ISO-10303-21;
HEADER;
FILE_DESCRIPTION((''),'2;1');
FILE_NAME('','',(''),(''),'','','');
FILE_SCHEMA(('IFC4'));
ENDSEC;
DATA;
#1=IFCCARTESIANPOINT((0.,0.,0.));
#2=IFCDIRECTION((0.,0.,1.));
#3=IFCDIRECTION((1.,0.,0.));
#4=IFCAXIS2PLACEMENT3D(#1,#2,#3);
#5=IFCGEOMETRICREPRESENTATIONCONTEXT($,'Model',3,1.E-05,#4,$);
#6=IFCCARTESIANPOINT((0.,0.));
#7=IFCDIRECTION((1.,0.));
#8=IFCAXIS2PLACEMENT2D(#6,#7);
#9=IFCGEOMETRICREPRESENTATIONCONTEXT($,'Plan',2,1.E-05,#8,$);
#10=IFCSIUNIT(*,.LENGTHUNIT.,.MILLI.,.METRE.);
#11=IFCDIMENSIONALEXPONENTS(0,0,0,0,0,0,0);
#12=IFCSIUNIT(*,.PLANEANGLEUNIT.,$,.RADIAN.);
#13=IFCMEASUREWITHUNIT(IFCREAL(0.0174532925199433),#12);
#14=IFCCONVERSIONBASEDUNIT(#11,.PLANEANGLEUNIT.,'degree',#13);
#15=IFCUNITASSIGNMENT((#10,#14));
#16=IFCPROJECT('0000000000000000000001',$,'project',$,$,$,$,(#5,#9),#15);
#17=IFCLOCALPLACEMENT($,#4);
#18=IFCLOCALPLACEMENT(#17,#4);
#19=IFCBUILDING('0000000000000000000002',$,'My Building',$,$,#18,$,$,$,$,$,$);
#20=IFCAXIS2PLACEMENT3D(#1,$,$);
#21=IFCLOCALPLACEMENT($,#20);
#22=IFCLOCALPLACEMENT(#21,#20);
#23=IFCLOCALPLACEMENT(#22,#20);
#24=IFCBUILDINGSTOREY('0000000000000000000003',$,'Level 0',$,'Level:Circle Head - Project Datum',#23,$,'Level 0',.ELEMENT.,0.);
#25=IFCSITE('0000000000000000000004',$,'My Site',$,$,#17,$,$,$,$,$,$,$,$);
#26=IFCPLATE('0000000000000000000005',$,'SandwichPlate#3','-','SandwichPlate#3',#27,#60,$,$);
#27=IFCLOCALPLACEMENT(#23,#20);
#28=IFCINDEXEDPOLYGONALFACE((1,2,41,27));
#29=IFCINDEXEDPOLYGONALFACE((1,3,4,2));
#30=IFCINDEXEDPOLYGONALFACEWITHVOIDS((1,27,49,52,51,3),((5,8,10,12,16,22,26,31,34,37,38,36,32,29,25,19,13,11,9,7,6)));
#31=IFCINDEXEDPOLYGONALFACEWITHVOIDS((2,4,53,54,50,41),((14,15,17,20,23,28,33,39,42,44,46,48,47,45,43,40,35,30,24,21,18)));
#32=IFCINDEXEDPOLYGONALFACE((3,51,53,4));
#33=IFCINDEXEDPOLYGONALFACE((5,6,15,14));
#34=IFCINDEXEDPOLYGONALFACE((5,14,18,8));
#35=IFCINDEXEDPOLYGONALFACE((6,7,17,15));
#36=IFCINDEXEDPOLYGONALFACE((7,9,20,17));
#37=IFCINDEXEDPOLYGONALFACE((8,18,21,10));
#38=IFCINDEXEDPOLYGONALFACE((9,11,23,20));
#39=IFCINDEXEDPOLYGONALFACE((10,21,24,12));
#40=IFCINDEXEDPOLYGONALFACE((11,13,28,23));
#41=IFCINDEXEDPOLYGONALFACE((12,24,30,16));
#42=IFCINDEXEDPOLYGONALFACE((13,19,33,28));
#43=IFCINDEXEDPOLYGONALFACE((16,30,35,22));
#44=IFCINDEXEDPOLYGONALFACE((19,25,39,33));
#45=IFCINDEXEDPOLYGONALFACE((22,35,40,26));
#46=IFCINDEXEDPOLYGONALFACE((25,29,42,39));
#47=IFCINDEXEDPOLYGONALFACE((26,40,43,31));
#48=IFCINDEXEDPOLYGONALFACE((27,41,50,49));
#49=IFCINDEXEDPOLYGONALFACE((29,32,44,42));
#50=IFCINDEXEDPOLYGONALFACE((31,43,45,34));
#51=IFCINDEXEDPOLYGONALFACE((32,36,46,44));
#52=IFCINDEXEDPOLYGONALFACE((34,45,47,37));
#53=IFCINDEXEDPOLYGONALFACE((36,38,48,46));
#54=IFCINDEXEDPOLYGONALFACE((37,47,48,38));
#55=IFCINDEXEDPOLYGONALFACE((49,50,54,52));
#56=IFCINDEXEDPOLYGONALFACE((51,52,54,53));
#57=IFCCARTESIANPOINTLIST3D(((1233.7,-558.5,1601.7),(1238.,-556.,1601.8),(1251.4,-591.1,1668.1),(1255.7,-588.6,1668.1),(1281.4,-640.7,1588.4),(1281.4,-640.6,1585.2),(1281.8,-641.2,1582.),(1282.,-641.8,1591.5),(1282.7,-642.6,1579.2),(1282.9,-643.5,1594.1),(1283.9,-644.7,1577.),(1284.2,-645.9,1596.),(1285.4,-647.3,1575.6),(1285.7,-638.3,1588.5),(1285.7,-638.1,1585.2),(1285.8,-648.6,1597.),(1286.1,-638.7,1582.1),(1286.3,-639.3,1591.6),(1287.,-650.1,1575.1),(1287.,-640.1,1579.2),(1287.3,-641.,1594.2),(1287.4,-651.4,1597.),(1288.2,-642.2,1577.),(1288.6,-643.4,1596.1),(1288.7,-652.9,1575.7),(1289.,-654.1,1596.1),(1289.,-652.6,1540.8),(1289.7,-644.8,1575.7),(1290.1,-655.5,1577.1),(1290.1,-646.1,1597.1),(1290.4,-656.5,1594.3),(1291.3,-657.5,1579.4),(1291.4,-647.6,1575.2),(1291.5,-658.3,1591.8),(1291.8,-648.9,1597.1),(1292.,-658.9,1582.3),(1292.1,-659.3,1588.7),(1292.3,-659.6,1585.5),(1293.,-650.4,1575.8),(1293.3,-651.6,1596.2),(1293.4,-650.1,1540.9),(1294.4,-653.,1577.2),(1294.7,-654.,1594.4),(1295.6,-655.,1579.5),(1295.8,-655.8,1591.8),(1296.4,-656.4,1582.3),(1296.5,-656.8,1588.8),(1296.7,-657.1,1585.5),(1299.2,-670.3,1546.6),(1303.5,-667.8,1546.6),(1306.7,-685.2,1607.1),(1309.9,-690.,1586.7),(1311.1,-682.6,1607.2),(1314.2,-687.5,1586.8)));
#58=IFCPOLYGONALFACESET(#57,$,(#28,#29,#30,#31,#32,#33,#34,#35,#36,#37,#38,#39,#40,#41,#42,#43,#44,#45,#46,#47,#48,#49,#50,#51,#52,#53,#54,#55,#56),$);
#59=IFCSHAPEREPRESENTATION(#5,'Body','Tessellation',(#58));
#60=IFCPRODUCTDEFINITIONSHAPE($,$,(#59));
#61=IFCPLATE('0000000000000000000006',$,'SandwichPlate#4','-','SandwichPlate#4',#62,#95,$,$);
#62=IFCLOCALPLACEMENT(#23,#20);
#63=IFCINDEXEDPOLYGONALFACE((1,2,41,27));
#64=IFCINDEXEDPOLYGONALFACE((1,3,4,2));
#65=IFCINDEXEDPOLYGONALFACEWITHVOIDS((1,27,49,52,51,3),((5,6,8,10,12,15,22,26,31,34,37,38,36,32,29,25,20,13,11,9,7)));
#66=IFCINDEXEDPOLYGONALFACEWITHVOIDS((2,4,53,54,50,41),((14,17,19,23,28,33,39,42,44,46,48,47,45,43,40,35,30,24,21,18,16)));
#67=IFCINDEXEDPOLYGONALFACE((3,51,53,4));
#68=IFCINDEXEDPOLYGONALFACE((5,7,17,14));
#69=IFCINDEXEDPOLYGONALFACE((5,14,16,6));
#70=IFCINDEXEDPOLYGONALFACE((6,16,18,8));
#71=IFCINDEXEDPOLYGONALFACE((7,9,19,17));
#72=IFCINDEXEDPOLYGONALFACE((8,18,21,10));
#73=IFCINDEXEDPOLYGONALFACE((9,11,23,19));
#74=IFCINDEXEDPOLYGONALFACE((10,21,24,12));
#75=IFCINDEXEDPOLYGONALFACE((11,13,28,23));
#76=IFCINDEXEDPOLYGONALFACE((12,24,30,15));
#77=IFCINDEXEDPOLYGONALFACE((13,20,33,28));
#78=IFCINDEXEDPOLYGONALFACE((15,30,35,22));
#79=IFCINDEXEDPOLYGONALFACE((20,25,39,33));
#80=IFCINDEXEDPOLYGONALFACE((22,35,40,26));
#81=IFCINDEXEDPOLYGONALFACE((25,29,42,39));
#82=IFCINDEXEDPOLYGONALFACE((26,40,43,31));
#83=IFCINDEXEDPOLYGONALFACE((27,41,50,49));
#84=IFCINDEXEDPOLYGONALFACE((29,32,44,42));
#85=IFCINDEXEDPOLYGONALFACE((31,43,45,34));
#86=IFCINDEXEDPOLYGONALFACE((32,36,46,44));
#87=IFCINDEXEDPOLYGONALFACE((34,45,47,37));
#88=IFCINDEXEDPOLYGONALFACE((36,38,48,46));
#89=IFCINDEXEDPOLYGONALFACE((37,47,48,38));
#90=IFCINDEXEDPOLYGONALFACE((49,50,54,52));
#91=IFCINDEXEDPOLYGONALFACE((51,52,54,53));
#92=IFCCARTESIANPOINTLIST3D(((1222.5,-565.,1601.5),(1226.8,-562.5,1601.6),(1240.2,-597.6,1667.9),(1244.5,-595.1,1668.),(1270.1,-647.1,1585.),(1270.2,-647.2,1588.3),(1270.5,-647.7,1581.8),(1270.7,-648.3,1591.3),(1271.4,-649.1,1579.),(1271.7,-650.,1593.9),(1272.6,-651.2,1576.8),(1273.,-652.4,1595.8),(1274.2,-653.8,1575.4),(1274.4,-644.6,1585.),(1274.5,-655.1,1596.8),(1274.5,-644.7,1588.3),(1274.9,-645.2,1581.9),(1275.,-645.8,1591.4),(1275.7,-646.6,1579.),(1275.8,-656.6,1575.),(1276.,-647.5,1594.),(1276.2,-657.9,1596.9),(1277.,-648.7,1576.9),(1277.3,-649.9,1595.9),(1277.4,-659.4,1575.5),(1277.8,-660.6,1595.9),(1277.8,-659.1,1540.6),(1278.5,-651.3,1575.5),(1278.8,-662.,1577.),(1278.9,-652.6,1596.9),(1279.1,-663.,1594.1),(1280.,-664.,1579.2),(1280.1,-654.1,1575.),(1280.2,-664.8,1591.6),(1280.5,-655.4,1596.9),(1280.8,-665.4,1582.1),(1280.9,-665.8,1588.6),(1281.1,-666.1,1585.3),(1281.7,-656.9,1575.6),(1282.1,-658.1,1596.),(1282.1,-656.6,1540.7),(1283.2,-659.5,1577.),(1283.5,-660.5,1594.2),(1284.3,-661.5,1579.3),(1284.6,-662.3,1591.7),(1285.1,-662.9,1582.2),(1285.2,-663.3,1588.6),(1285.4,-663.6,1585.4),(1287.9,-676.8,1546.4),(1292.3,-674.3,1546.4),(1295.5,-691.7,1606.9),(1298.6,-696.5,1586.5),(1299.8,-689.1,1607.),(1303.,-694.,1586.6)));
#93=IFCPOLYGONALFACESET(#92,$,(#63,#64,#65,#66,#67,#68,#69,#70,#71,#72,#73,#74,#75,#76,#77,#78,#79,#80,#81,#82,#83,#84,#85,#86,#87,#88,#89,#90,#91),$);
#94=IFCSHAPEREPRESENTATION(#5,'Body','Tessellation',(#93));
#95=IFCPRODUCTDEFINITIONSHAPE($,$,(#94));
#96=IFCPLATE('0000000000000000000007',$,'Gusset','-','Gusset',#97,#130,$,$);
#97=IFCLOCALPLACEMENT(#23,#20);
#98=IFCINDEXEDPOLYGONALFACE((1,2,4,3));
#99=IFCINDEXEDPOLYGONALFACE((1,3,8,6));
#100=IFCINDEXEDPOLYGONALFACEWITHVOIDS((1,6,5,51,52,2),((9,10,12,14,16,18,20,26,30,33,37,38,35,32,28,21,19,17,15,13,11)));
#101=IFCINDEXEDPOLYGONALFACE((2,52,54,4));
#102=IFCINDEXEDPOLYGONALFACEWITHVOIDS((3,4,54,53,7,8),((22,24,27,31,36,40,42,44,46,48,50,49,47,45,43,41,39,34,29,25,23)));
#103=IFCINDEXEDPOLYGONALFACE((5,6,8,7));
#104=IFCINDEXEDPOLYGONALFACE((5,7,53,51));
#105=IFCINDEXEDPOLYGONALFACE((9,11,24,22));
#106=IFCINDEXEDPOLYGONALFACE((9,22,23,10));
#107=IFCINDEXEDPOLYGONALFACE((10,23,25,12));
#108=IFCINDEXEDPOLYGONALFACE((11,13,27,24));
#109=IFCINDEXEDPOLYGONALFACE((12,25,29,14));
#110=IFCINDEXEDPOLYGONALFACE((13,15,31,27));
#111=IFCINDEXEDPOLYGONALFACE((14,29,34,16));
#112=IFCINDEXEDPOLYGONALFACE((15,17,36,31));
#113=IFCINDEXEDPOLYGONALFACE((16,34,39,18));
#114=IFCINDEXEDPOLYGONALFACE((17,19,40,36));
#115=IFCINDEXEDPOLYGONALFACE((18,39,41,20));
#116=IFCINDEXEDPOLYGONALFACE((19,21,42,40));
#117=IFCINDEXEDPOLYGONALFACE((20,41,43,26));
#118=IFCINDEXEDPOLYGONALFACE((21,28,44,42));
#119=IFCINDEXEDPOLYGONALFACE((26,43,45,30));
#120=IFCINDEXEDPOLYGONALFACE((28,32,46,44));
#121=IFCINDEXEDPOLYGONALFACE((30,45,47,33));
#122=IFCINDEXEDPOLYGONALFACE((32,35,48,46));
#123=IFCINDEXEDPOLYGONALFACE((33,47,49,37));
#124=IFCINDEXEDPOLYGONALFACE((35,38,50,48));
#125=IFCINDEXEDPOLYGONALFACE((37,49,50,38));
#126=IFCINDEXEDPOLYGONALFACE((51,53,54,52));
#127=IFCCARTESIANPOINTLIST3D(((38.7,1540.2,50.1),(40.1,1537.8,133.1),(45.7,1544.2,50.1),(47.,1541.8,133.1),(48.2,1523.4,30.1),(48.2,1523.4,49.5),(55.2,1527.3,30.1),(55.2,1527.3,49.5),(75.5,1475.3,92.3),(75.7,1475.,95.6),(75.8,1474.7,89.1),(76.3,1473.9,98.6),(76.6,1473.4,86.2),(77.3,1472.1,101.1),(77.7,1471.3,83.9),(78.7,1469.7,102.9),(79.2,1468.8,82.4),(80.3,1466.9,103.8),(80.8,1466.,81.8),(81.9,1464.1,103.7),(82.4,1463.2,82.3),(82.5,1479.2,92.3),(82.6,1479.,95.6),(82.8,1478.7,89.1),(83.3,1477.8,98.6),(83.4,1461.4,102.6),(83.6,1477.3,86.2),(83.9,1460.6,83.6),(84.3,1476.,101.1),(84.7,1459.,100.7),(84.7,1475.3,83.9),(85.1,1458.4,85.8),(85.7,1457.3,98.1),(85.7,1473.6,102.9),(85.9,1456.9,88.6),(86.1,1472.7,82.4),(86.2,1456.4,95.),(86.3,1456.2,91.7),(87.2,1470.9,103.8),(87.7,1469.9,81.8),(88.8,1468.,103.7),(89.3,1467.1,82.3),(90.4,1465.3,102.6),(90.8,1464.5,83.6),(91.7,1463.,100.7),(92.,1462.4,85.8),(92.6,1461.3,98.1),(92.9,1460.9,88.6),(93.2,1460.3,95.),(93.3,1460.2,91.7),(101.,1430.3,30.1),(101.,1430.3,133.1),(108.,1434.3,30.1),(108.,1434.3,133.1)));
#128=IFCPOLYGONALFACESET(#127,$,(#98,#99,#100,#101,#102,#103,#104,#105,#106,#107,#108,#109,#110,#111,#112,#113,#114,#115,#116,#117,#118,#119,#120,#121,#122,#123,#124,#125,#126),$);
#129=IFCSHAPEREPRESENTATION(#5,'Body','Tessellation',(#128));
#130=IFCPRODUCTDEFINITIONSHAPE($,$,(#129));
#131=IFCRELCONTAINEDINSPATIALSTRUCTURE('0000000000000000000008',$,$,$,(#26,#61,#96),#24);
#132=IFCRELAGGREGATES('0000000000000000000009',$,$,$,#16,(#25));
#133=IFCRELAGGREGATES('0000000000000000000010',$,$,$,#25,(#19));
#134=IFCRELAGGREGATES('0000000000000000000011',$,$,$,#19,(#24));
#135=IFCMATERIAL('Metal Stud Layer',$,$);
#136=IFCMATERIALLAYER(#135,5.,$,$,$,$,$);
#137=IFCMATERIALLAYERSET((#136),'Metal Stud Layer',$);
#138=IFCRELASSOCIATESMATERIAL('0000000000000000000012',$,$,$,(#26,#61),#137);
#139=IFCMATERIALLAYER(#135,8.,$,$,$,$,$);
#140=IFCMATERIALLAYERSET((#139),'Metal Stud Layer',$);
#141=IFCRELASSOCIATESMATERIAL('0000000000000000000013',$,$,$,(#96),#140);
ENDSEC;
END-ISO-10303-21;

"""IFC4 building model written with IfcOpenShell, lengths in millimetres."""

from ifc_helpers import new_model, entity, si_unit, converted_unit, point, frame, frame_2d, origin, origin_with_axes, origin_2d_with_axis, place, context, project, spatial, polyline, circle_curve, line_curve, trimmed, segment, composite_curve, circle, outline, extrude, material, layer, layer_set, element, save


model = new_model("IFC4")

# Units and contexts
model_context = context("Model", 3, precision=1e-05, world=origin_with_axes())
plan_context = context("Plan", 2, precision=1e-05, world=origin_2d_with_axis())
ifc_project = project(units=[si_unit("LENGTHUNIT", "METRE", prefix="MILLI"), converted_unit("PLANEANGLEUNIT", "degree", entity("IfcReal", 0.0174532925199433), si_unit("PLANEANGLEUNIT", "RADIAN"), dimensions=[0, 0, 0, 0, 0, 0, 0])], contexts=[model_context, plan_context])

# Site, building, storey
site_placement = place(None, origin_with_axes())
site = spatial("IfcSite", under=ifc_project, at=site_placement, Name="My Site")
building_placement = place(site_placement, origin_with_axes())
building = spatial("IfcBuilding", under=site, at=building_placement, Name="My Building")
placement_1 = place(None, origin())
placement_2 = place(placement_1, origin())
storey_placement = place(placement_2, origin())
storey = spatial("IfcBuildingStorey", under=building, at=storey_placement, Name="Level 0", ObjectType="Level:Circle Head - Project Datum", LongName="Level 0", CompositionType="ELEMENT", Elevation=0.0)

# Shared definitions
ifc_material_1 = material(Name="Metal Stud Layer")
ifc_layer_1 = layer(ifc_material_1, 5.0)
ifc_layer_set_1 = layer_set([ifc_layer_1], Name="Metal Stud Layer")

# Plates, openings
plate_1_placement = place(storey_placement, frame((1300.0, -661.4, 1533.5), z_axis=(-0.865935, -0.499948, -0.014432), x_axis=(0.232925, -0.428638, 0.872935)))
plate_1 = element("IfcPlate", 1, at=plate_1_placement, inside=storey, material=ifc_layer_set_1, Name="SandwichPlate#3", Description="-", ObjectType="SandwichPlate#3", context=model_context, shape_type="SweptSolid", body=[
    extrude(outline(polyline([(0.0, 0.0), (76.0, 0.0), (76.0, 140.0), (0.0, 140.0), (0.0, 0.0)])), origin_with_axes(), (0.0, 0.0, 1.0), 5.0),
])
opening_1_placement = place(plate_1_placement, frame((0.0, 0.0, 0.0), z_axis=(0.0, 0.0, 1.0), x_axis=(1.0, 0.0, 0.0)))
element("IfcOpeningElement", 2, at=opening_1_placement, cuts=plate_1, ObjectType="Opening", context=model_context, shape_type="SweptSolid", body=[
    extrude(outline(polyline([(0.0, 0.0), (15.0, 0.0), (0.0, 15.0), (0.0, 0.0)])), origin(), (0.0, 0.0, 1.0), 5.0),
])
opening_2_placement = place(plate_1_placement, frame((0.0, 0.0, 0.0), z_axis=(0.0, 0.0, 1.0), x_axis=(1.0, 0.0, 0.0)))
element("IfcOpeningElement", 3, at=opening_2_placement, cuts=plate_1, ObjectType="Opening", context=model_context, shape_type="SweptSolid", body=[
    extrude(outline(polyline([(76.0, 0.0), (76.0, 15.0), (61.0, 0.0), (76.0, 0.0)])), origin(), (0.0, 0.0, 1.0), 5.0),
])
opening_3_placement = place(plate_1_placement, frame((38.0, 40.0, -0.5), z_axis=(0.0, 0.0, 1.0), x_axis=(0.0, 1.0, 0.0)))
element("IfcOpeningElement", 4, at=opening_3_placement, cuts=plate_1, ObjectType="Opening", context=model_context, shape_type="SweptSolid", body=[
    extrude(circle(Radius=11.0, at=origin_2d_with_axis()), origin(), (0.0, 0.0, 1.0), 6.0),
])
plate_2_placement = place(storey_placement, frame((1288.7, -667.9, 1533.4), z_axis=(-0.865935, -0.499948, -0.014432), x_axis=(0.232925, -0.428638, 0.872935)))
plate_2 = element("IfcPlate", 5, at=plate_2_placement, inside=storey, material=ifc_layer_set_1, Name="SandwichPlate#4", Description="-", ObjectType="SandwichPlate#4", context=model_context, shape_type="SweptSolid", body=[
    extrude(outline(polyline([(0.0, 0.0), (76.0, 0.0), (76.0, 140.0), (0.0, 140.0), (0.0, 0.0)])), origin_with_axes(), (0.0, 0.0, 1.0), 5.0),
])
opening_4_placement = place(plate_2_placement, frame((0.0, 0.0, 0.0), z_axis=(0.0, 0.0, 1.0), x_axis=(1.0, 0.0, 0.0)))
element("IfcOpeningElement", 6, at=opening_4_placement, cuts=plate_2, ObjectType="Opening", context=model_context, shape_type="SweptSolid", body=[
    extrude(outline(polyline([(0.0, 0.0), (15.0, 0.0), (0.0, 15.0), (0.0, 0.0)])), origin(), (0.0, 0.0, 1.0), 5.0),
])
opening_5_placement = place(plate_2_placement, frame((0.0, 0.0, 0.0), z_axis=(0.0, 0.0, 1.0), x_axis=(1.0, 0.0, 0.0)))
element("IfcOpeningElement", 7, at=opening_5_placement, cuts=plate_2, ObjectType="Opening", context=model_context, shape_type="SweptSolid", body=[
    extrude(outline(polyline([(76.0, 0.0), (76.0, 15.0), (61.0, 0.0), (76.0, 0.0)])), origin(), (0.0, 0.0, 1.0), 5.0),
])
opening_6_placement = place(plate_2_placement, frame((38.0, 40.0, -0.5), z_axis=(0.0, 0.0, 1.0), x_axis=(0.0, 1.0, 0.0)))
element("IfcOpeningElement", 8, at=opening_6_placement, cuts=plate_2, ObjectType="Opening", context=model_context, shape_type="SweptSolid", body=[
    extrude(circle(Radius=11.0, at=origin_2d_with_axis()), origin(), (0.0, 0.0, 1.0), 6.0),
])
ifc_layer_2 = layer(ifc_material_1, 8.0)
ifc_layer_set_2 = layer_set([ifc_layer_2], Name="Metal Stud Layer")
plate_3_placement = place(storey_placement, frame((41.3, 1535.6, 143.5), z_axis=(0.869914, 0.493203, 0.0), x_axis=(0.492931, -0.869436, -0.033166)))
plate_3 = element("IfcPlate", 9, at=plate_3_placement, inside=storey, material=ifc_layer_set_2, Name="Gusset", Description="-", ObjectType="Gusset", context=model_context, shape_type="SweptSolid", body=[
    extrude(outline(polyline([(17.1, 93.5), (-2.2, 93.5), (-2.2, 10.5), (121.3, 6.4), (124.7, 109.3), (17.8, 112.9), (17.1, 93.5)])), origin_with_axes(), (0.0, 0.0, 1.0), 8.0),
])
opening_7_placement = place(plate_3_placement, frame((81.9, 48.0, 8.5), z_axis=(0.0, 0.0, -1.0), x_axis=(0.862665, -0.505775, 0.0)))
element("IfcOpeningElement", 10, at=opening_7_placement, cuts=plate_3, ObjectType="Opening", context=model_context, shape_type="SweptSolid", body=[
    extrude(circle(Radius=11.0, at=origin_2d_with_axis()), origin(), (0.0, 0.0, 1.0), 9.0),
])
opening_8_placement = place(plate_3_placement, origin_with_axes())
element("IfcOpeningElement", 11, at=opening_8_placement, cuts=plate_3, ObjectType="Opening", context=model_context, shape_type="SweptSolid", body=[
    extrude(outline(composite_curve([segment(trimmed(line_curve((17.1, 93.5), (-1.0, 0.0), 19.347323), [point((17.1, 93.5))], [point((-2.2, 93.5))], True, "CARTESIAN"), True, "CONTINUOUS"), segment(trimmed(circle_curve(frame_2d((-2.2, 113.5), x_axis=(1.0, 0.0)), 20.0), [point((-2.2, 93.5))], [point((17.8, 112.9))], True, "CARTESIAN"), True, "CONTINUOUS"), segment(trimmed(line_curve((17.8, 112.9), (-0.033166, -0.99945), 19.347323), [point((17.8, 112.9))], [point((17.1, 93.5))], True, "CARTESIAN"), True, "CONTINUOUS")], self_intersect=False)), origin(), (0.0, 0.0, 1.0), 8.0),
])

save(model, "model.ifc")
